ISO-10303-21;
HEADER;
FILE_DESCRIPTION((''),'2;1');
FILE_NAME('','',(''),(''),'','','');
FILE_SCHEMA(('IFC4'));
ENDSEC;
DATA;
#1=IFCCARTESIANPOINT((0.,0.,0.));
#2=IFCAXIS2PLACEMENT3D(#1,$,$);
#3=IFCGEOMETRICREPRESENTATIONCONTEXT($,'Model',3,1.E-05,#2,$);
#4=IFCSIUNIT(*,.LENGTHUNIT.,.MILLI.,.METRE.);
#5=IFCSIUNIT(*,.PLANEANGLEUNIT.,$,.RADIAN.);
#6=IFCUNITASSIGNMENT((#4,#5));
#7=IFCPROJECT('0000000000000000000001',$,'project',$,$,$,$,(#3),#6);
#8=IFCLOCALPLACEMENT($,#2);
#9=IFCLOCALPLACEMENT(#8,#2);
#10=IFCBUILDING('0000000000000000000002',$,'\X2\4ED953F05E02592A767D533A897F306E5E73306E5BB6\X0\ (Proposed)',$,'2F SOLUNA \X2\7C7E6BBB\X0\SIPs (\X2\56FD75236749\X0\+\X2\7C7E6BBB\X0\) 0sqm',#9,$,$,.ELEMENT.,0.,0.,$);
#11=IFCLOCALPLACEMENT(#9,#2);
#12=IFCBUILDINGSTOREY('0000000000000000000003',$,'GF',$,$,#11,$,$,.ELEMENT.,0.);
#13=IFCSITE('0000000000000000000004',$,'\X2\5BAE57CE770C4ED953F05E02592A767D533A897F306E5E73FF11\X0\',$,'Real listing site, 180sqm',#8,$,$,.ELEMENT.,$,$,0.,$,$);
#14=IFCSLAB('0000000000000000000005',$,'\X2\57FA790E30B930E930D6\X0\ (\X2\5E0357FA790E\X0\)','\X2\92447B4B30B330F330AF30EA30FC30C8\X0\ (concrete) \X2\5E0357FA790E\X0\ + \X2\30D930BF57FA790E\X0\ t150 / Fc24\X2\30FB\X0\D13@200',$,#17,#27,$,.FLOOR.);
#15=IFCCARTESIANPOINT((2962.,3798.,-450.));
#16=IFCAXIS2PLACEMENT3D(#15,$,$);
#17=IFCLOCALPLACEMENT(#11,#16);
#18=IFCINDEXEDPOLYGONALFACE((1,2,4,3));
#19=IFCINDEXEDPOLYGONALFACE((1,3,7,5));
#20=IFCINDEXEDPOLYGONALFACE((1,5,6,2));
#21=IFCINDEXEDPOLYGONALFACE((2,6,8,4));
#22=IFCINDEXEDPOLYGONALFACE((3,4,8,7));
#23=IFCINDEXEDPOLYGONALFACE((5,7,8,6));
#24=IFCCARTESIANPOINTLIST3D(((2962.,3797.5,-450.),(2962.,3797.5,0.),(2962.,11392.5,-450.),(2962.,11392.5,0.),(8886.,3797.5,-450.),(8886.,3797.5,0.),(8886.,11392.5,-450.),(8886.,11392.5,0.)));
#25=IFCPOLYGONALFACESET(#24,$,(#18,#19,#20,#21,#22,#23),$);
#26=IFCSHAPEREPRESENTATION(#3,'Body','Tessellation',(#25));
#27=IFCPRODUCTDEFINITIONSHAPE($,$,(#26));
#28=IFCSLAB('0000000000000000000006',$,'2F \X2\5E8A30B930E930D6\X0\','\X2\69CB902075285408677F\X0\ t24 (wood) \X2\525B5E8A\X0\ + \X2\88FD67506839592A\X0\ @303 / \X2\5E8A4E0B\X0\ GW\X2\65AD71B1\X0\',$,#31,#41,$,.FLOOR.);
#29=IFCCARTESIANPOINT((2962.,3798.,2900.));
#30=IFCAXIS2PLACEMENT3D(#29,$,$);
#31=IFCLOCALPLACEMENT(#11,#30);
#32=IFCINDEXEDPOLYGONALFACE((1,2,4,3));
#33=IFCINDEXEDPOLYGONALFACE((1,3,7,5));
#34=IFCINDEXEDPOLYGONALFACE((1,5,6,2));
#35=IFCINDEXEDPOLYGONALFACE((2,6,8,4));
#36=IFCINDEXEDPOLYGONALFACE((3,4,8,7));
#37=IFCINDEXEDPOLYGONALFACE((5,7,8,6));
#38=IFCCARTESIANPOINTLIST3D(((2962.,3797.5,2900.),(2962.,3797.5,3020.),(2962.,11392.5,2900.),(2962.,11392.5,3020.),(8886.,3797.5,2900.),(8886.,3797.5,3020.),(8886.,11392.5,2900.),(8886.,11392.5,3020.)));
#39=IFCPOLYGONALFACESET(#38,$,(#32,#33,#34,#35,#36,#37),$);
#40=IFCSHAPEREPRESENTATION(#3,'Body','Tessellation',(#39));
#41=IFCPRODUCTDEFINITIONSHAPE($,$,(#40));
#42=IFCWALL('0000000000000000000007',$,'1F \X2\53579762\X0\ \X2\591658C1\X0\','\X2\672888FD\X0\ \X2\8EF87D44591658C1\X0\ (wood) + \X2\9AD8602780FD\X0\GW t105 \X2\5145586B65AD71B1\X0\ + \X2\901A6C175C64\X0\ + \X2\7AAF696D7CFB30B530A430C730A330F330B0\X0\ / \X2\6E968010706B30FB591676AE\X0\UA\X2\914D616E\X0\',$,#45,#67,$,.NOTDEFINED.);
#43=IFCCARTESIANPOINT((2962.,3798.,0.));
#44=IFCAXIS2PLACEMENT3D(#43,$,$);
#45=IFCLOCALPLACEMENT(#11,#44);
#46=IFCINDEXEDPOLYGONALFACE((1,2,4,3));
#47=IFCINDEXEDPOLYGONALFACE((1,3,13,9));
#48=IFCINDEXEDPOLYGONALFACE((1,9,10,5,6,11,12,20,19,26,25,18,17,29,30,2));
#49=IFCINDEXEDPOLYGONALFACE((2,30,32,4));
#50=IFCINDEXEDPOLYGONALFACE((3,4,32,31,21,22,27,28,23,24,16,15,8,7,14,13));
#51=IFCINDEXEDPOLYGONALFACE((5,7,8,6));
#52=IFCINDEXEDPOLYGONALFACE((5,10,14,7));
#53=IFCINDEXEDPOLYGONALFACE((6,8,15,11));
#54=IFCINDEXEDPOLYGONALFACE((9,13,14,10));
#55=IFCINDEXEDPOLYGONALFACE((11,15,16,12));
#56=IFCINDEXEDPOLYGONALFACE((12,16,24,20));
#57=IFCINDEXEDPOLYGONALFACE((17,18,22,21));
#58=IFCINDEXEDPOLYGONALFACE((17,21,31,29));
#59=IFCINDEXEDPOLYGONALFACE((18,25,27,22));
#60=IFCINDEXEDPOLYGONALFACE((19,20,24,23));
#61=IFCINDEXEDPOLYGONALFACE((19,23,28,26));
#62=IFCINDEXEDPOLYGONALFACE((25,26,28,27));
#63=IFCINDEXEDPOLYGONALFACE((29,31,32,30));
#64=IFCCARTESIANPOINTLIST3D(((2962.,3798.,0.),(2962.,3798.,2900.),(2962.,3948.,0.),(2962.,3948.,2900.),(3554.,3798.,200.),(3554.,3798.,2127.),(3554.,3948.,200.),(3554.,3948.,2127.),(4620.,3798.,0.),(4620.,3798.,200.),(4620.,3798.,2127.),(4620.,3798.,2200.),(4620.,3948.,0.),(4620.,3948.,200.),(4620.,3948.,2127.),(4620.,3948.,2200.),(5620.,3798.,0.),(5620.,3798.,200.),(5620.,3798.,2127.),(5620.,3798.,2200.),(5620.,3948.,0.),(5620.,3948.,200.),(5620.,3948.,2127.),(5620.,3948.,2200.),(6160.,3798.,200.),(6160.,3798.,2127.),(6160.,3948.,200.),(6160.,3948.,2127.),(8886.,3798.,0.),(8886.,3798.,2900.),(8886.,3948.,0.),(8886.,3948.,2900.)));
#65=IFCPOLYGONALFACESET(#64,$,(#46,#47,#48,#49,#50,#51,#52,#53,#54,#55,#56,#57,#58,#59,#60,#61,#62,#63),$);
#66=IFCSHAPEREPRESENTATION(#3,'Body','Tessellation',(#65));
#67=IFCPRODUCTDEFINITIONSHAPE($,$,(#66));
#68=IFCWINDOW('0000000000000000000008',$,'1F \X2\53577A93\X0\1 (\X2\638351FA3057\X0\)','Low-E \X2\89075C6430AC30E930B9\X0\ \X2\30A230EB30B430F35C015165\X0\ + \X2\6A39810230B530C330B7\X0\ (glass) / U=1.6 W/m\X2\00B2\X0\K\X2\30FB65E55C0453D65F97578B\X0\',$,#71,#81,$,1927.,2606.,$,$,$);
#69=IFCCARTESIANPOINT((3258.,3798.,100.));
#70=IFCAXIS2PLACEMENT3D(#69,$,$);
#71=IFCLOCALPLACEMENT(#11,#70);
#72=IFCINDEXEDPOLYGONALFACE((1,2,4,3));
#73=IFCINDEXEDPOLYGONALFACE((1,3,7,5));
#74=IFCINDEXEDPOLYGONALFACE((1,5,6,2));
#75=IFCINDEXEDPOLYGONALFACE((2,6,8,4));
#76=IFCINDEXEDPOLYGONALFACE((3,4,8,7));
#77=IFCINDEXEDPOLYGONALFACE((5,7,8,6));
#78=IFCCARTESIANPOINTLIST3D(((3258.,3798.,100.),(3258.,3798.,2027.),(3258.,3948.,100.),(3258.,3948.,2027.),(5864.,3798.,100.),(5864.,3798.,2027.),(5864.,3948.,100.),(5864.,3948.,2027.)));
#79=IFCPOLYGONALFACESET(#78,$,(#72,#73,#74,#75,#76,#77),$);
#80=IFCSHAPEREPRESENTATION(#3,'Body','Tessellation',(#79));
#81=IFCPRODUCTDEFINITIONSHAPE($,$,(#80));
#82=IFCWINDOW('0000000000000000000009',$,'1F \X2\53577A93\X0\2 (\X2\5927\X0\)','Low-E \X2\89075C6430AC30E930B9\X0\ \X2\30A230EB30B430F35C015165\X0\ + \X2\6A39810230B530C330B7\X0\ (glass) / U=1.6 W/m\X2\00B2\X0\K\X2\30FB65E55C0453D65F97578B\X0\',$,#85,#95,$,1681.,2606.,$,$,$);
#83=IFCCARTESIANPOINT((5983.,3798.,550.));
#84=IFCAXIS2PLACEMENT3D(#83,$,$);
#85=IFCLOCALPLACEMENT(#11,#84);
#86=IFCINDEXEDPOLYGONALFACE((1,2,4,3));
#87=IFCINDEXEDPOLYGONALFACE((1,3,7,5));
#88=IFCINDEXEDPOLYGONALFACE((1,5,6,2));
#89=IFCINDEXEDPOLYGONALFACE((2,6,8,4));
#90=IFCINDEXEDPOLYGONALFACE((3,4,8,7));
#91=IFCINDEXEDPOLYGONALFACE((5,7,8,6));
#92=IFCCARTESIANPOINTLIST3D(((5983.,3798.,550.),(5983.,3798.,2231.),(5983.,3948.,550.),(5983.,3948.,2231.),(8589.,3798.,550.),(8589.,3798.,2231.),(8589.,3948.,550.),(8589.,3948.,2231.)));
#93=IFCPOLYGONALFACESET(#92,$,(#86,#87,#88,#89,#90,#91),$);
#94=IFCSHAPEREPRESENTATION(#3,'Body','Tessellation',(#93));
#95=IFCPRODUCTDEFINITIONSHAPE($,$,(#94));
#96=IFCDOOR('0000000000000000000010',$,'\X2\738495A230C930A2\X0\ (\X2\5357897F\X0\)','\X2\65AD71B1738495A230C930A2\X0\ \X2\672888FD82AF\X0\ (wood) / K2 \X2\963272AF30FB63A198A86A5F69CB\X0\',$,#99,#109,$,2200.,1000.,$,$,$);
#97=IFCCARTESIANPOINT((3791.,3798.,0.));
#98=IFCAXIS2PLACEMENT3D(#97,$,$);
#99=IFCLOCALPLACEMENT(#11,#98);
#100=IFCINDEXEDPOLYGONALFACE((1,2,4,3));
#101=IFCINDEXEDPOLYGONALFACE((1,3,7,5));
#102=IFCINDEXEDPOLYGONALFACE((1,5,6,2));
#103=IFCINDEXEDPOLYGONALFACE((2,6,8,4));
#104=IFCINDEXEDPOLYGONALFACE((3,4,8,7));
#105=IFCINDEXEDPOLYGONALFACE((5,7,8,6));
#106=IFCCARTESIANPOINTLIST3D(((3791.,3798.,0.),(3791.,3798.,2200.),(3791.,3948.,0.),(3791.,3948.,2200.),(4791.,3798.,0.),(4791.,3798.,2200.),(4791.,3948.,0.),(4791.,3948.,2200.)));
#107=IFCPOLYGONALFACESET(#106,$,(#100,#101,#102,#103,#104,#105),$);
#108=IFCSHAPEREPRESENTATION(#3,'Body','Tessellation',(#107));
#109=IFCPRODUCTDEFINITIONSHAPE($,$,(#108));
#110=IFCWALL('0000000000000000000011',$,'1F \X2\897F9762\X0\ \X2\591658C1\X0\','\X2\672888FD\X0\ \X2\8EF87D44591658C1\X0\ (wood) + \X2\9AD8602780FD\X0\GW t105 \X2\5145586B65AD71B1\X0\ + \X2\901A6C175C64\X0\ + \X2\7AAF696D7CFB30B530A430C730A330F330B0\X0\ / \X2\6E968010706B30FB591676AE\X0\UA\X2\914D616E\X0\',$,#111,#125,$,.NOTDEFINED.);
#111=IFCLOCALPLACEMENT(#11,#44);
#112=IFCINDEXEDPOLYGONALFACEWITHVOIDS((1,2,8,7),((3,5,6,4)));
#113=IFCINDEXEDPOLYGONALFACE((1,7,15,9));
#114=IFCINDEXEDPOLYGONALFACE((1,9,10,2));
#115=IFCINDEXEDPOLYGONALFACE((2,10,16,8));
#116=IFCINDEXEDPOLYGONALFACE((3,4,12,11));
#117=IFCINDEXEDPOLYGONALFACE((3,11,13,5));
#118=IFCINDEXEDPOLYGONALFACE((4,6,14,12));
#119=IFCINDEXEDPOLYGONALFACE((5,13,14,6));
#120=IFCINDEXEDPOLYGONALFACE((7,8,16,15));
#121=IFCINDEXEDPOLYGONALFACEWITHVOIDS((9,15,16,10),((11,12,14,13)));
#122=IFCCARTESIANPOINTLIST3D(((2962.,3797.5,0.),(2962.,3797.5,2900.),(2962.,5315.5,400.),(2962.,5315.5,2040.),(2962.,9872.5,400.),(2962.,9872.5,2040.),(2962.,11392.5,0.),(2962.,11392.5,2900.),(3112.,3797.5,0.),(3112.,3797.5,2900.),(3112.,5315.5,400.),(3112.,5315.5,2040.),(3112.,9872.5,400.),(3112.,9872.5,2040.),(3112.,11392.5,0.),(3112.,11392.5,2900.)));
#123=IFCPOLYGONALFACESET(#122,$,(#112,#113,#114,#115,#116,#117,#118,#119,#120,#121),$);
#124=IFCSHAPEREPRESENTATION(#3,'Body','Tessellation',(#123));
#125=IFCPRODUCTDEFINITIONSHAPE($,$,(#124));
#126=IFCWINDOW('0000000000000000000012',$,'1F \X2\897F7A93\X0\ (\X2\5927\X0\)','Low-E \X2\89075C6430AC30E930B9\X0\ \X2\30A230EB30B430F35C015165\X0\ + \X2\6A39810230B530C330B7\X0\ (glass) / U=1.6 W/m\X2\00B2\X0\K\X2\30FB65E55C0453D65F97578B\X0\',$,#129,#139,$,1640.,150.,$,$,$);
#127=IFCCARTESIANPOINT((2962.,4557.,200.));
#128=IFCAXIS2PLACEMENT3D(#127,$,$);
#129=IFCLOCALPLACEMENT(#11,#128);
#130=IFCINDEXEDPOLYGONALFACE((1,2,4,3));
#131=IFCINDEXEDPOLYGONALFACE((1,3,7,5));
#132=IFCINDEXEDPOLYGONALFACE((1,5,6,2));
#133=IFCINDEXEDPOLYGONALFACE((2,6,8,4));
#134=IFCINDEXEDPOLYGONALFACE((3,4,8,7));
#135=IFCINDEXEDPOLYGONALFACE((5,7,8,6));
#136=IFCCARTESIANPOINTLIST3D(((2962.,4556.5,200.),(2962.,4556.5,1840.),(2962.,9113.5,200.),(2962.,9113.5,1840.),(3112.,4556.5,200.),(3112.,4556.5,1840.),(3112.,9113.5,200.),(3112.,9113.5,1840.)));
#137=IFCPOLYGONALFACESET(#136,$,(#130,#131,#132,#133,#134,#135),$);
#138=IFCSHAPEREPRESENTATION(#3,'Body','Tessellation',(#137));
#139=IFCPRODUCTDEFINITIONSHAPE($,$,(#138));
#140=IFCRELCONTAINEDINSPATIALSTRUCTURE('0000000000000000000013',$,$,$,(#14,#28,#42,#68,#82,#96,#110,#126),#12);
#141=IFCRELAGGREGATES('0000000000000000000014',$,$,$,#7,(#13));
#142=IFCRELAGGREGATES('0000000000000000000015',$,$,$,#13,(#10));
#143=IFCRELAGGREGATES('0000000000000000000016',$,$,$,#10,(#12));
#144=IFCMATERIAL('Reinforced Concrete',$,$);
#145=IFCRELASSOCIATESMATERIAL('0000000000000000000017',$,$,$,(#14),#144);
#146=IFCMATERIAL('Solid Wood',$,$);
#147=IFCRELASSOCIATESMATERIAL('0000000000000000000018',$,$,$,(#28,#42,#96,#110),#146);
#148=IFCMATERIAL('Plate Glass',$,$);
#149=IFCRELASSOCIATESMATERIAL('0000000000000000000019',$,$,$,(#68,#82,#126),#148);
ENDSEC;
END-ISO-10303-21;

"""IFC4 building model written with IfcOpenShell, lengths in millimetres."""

from ifc_helpers import new_model, si_unit, frame, frame_2d, origin, place, context, project, spatial, rectangle, extrude, material, element, fill, save


model = new_model("IFC4")

# Units and contexts
model_context = context("Model", 3, precision=1e-05, world=origin())
ifc_project = project(units=[si_unit("LENGTHUNIT", "METRE", prefix="MILLI"), si_unit("PLANEANGLEUNIT", "RADIAN")], contexts=[model_context])

# Site, building, storey
site_placement = place(None, origin())
site = spatial("IfcSite", under=ifc_project, at=site_placement, Name="宮城県仙台市太白区西の平１", ObjectType="Real listing site, 180sqm", CompositionType="ELEMENT", RefElevation=0.0)
building_placement = place(site_placement, origin())
building = spatial("IfcBuilding", under=site, at=building_placement, Name="仙台市太白区西の平の家 (Proposed)", ObjectType="2F SOLUNA 籾殻SIPs (国産杉+籾殻) 0sqm", CompositionType="ELEMENT", ElevationOfRefHeight=0.0, ElevationOfTerrain=0.0)
storey_placement = place(building_placement, origin())
storey = spatial("IfcBuildingStorey", under=building, at=storey_placement, Name="GF", CompositionType="ELEMENT", Elevation=0.0)

# Slabs
ifc_material_1 = material(Name="Reinforced Concrete")
slab_1_placement = place(storey_placement, frame((2962.0, 3798.0, -450.0)))
element("IfcSlab", 1, at=slab_1_placement, inside=storey, material=ifc_material_1, Name="基礎スラブ (布基礎)", Description="鉄筋コンクリート (concrete) 布基礎 + ベタ基礎 t150 / Fc24・D13@200", PredefinedType="FLOOR", context=model_context, shape_type="SweptSolid", body=[
    extrude(rectangle(XDim=5924.0, YDim=7595.0, at=frame_2d((2962.0, 3797.0))), frame((2962.0, 3798.0, -450.0)), (0.0, 0.0, 1.0), 450.0),
])
ifc_material_2 = material(Name="Solid Wood")
slab_2_placement = place(storey_placement, frame((2962.0, 3798.0, 2900.0)))
element("IfcSlab", 2, at=slab_2_placement, inside=storey, material=ifc_material_2, Name="2F 床スラブ", Description="構造用合板 t24 (wood) 剛床 + 製材根太 @303 / 床下 GW断熱", PredefinedType="FLOOR", context=model_context, shape_type="SweptSolid", body=[
    extrude(rectangle(XDim=5924.0, YDim=7595.0, at=frame_2d((2962.0, 3797.0))), frame((2962.0, 3798.0, 2900.0)), (0.0, 0.0, 1.0), 120.0),
])

# Wall, openings, windows, door
wall_1_placement = place(storey_placement, frame((2962.0, 3798.0, 0.0)))
wall_1 = element("IfcWall", 3, at=wall_1_placement, inside=storey, material=ifc_material_2, Name="1F 南面 外壁", Description="木製 軸組外壁 (wood) + 高性能GW t105 充填断熱 + 通気層 + 窯業系サイディング / 準耐火・外皮UA配慮", PredefinedType="NOTDEFINED", context=model_context, shape_type="SweptSolid", body=[
    extrude(rectangle(XDim=5924.0, YDim=150.0, at=frame_2d((2962.0, 75.0))), frame((2962.0, 3798.0, 0.0)), (0.0, 0.0, 1.0), 2900.0),
])
opening_1_placement = place(storey_placement, frame((3258.0, 3798.0, 100.0)))
opening_1 = element("IfcOpeningElement", 4, at=opening_1_placement, cuts=wall_1, PredefinedType="NOTDEFINED", context=model_context, shape_type="SweptSolid", body=[
    extrude(rectangle(XDim=2606.0, YDim=150.0, at=frame_2d((1303.0, 75.0))), frame((3258.0, 3798.0, 100.0)), (0.0, 0.0, 1.0), 1927.0),
])
opening_2_placement = place(storey_placement, frame((5983.0, 3798.0, 550.0)))
opening_2 = element("IfcOpeningElement", 5, at=opening_2_placement, cuts=wall_1, PredefinedType="NOTDEFINED", context=model_context, shape_type="SweptSolid", body=[
    extrude(rectangle(XDim=2606.0, YDim=150.0, at=frame_2d((1303.0, 75.0))), frame((5983.0, 3798.0, 550.0)), (0.0, 0.0, 1.0), 1681.0),
])
opening_3_placement = place(storey_placement, frame((3791.0, 3798.0, 0.0)))
opening_3 = element("IfcOpeningElement", 6, at=opening_3_placement, cuts=wall_1, PredefinedType="NOTDEFINED", context=model_context, shape_type="SweptSolid", body=[
    extrude(rectangle(XDim=1000.0, YDim=150.0, at=frame_2d((500.0, 75.0))), frame((3791.0, 3798.0, 0.0)), (0.0, 0.0, 1.0), 2200.0),
])
ifc_material_3 = material(Name="Plate Glass")
window_1_placement = place(storey_placement, frame((3258.0, 3798.0, 100.0)))
window_1 = element("IfcWindow", 7, at=window_1_placement, inside=storey, material=ifc_material_3, Name="1F 南窓1 (掃出し)", Description="Low-E 複層ガラス アルゴン封入 + 樹脂サッシ (glass) / U=1.6 W/m²K・日射取得型", OverallHeight=1927.0, OverallWidth=2606.0, context=model_context, shape_type="SweptSolid", body=[
    extrude(rectangle(XDim=2606.0, YDim=150.0, at=frame_2d((1303.0, 75.0))), frame((3258.0, 3798.0, 100.0)), (0.0, 0.0, 1.0), 1927.0),
])
fill(opening_1, window_1)
window_2_placement = place(storey_placement, frame((5983.0, 3798.0, 550.0)))
window_2 = element("IfcWindow", 8, at=window_2_placement, inside=storey, material=ifc_material_3, Name="1F 南窓2 (大)", Description="Low-E 複層ガラス アルゴン封入 + 樹脂サッシ (glass) / U=1.6 W/m²K・日射取得型", OverallHeight=1681.0, OverallWidth=2606.0, context=model_context, shape_type="SweptSolid", body=[
    extrude(rectangle(XDim=2606.0, YDim=150.0, at=frame_2d((1303.0, 75.0))), frame((5983.0, 3798.0, 550.0)), (0.0, 0.0, 1.0), 1681.0),
])
fill(opening_2, window_2)
door_placement = place(storey_placement, frame((3791.0, 3798.0, 0.0)))
door = element("IfcDoor", 9, at=door_placement, inside=storey, material=ifc_material_2, Name="玄関ドア (南西)", Description="断熱玄関ドア 木製芯 (wood) / K2 防犯・採風機構", OverallHeight=2200.0, OverallWidth=1000.0, context=model_context, shape_type="SweptSolid", body=[
    extrude(rectangle(XDim=1000.0, YDim=150.0, at=frame_2d((500.0, 75.0))), frame((3791.0, 3798.0, 0.0)), (0.0, 0.0, 1.0), 2200.0),
])
fill(opening_3, door)

# Wall, opening, window
wall_2_placement = place(storey_placement, frame((2962.0, 3798.0, 0.0)))
wall_2 = element("IfcWall", 10, at=wall_2_placement, inside=storey, material=ifc_material_2, Name="1F 西面 外壁", Description="木製 軸組外壁 (wood) + 高性能GW t105 充填断熱 + 通気層 + 窯業系サイディング / 準耐火・外皮UA配慮", PredefinedType="NOTDEFINED", context=model_context, shape_type="SweptSolid", body=[
    extrude(rectangle(XDim=150.0, YDim=7595.0, at=frame_2d((75.0, 3797.0))), frame((2962.0, 3798.0, 0.0)), (0.0, 0.0, 1.0), 2900.0),
])
opening_4_placement = place(storey_placement, frame((2962.0, 4557.0, 200.0)))
opening_4 = element("IfcOpeningElement", 11, at=opening_4_placement, cuts=wall_2, PredefinedType="NOTDEFINED", context=model_context, shape_type="SweptSolid", body=[
    extrude(rectangle(XDim=150.0, YDim=4557.0, at=frame_2d((75.0, 2278.0))), frame((2962.0, 4557.0, 200.0)), (0.0, 0.0, 1.0), 1640.0),
])
window_3_placement = place(storey_placement, frame((2962.0, 4557.0, 200.0)))
window_3 = element("IfcWindow", 12, at=window_3_placement, inside=storey, material=ifc_material_3, Name="1F 西窓 (大)", Description="Low-E 複層ガラス アルゴン封入 + 樹脂サッシ (glass) / U=1.6 W/m²K・日射取得型", OverallHeight=1640.0, OverallWidth=150.0, context=model_context, shape_type="SweptSolid", body=[
    extrude(rectangle(XDim=150.0, YDim=4557.0, at=frame_2d((75.0, 2278.0))), frame((2962.0, 4557.0, 200.0)), (0.0, 0.0, 1.0), 1640.0),
])
fill(opening_4, window_3)

save(model, "model.ifc")
